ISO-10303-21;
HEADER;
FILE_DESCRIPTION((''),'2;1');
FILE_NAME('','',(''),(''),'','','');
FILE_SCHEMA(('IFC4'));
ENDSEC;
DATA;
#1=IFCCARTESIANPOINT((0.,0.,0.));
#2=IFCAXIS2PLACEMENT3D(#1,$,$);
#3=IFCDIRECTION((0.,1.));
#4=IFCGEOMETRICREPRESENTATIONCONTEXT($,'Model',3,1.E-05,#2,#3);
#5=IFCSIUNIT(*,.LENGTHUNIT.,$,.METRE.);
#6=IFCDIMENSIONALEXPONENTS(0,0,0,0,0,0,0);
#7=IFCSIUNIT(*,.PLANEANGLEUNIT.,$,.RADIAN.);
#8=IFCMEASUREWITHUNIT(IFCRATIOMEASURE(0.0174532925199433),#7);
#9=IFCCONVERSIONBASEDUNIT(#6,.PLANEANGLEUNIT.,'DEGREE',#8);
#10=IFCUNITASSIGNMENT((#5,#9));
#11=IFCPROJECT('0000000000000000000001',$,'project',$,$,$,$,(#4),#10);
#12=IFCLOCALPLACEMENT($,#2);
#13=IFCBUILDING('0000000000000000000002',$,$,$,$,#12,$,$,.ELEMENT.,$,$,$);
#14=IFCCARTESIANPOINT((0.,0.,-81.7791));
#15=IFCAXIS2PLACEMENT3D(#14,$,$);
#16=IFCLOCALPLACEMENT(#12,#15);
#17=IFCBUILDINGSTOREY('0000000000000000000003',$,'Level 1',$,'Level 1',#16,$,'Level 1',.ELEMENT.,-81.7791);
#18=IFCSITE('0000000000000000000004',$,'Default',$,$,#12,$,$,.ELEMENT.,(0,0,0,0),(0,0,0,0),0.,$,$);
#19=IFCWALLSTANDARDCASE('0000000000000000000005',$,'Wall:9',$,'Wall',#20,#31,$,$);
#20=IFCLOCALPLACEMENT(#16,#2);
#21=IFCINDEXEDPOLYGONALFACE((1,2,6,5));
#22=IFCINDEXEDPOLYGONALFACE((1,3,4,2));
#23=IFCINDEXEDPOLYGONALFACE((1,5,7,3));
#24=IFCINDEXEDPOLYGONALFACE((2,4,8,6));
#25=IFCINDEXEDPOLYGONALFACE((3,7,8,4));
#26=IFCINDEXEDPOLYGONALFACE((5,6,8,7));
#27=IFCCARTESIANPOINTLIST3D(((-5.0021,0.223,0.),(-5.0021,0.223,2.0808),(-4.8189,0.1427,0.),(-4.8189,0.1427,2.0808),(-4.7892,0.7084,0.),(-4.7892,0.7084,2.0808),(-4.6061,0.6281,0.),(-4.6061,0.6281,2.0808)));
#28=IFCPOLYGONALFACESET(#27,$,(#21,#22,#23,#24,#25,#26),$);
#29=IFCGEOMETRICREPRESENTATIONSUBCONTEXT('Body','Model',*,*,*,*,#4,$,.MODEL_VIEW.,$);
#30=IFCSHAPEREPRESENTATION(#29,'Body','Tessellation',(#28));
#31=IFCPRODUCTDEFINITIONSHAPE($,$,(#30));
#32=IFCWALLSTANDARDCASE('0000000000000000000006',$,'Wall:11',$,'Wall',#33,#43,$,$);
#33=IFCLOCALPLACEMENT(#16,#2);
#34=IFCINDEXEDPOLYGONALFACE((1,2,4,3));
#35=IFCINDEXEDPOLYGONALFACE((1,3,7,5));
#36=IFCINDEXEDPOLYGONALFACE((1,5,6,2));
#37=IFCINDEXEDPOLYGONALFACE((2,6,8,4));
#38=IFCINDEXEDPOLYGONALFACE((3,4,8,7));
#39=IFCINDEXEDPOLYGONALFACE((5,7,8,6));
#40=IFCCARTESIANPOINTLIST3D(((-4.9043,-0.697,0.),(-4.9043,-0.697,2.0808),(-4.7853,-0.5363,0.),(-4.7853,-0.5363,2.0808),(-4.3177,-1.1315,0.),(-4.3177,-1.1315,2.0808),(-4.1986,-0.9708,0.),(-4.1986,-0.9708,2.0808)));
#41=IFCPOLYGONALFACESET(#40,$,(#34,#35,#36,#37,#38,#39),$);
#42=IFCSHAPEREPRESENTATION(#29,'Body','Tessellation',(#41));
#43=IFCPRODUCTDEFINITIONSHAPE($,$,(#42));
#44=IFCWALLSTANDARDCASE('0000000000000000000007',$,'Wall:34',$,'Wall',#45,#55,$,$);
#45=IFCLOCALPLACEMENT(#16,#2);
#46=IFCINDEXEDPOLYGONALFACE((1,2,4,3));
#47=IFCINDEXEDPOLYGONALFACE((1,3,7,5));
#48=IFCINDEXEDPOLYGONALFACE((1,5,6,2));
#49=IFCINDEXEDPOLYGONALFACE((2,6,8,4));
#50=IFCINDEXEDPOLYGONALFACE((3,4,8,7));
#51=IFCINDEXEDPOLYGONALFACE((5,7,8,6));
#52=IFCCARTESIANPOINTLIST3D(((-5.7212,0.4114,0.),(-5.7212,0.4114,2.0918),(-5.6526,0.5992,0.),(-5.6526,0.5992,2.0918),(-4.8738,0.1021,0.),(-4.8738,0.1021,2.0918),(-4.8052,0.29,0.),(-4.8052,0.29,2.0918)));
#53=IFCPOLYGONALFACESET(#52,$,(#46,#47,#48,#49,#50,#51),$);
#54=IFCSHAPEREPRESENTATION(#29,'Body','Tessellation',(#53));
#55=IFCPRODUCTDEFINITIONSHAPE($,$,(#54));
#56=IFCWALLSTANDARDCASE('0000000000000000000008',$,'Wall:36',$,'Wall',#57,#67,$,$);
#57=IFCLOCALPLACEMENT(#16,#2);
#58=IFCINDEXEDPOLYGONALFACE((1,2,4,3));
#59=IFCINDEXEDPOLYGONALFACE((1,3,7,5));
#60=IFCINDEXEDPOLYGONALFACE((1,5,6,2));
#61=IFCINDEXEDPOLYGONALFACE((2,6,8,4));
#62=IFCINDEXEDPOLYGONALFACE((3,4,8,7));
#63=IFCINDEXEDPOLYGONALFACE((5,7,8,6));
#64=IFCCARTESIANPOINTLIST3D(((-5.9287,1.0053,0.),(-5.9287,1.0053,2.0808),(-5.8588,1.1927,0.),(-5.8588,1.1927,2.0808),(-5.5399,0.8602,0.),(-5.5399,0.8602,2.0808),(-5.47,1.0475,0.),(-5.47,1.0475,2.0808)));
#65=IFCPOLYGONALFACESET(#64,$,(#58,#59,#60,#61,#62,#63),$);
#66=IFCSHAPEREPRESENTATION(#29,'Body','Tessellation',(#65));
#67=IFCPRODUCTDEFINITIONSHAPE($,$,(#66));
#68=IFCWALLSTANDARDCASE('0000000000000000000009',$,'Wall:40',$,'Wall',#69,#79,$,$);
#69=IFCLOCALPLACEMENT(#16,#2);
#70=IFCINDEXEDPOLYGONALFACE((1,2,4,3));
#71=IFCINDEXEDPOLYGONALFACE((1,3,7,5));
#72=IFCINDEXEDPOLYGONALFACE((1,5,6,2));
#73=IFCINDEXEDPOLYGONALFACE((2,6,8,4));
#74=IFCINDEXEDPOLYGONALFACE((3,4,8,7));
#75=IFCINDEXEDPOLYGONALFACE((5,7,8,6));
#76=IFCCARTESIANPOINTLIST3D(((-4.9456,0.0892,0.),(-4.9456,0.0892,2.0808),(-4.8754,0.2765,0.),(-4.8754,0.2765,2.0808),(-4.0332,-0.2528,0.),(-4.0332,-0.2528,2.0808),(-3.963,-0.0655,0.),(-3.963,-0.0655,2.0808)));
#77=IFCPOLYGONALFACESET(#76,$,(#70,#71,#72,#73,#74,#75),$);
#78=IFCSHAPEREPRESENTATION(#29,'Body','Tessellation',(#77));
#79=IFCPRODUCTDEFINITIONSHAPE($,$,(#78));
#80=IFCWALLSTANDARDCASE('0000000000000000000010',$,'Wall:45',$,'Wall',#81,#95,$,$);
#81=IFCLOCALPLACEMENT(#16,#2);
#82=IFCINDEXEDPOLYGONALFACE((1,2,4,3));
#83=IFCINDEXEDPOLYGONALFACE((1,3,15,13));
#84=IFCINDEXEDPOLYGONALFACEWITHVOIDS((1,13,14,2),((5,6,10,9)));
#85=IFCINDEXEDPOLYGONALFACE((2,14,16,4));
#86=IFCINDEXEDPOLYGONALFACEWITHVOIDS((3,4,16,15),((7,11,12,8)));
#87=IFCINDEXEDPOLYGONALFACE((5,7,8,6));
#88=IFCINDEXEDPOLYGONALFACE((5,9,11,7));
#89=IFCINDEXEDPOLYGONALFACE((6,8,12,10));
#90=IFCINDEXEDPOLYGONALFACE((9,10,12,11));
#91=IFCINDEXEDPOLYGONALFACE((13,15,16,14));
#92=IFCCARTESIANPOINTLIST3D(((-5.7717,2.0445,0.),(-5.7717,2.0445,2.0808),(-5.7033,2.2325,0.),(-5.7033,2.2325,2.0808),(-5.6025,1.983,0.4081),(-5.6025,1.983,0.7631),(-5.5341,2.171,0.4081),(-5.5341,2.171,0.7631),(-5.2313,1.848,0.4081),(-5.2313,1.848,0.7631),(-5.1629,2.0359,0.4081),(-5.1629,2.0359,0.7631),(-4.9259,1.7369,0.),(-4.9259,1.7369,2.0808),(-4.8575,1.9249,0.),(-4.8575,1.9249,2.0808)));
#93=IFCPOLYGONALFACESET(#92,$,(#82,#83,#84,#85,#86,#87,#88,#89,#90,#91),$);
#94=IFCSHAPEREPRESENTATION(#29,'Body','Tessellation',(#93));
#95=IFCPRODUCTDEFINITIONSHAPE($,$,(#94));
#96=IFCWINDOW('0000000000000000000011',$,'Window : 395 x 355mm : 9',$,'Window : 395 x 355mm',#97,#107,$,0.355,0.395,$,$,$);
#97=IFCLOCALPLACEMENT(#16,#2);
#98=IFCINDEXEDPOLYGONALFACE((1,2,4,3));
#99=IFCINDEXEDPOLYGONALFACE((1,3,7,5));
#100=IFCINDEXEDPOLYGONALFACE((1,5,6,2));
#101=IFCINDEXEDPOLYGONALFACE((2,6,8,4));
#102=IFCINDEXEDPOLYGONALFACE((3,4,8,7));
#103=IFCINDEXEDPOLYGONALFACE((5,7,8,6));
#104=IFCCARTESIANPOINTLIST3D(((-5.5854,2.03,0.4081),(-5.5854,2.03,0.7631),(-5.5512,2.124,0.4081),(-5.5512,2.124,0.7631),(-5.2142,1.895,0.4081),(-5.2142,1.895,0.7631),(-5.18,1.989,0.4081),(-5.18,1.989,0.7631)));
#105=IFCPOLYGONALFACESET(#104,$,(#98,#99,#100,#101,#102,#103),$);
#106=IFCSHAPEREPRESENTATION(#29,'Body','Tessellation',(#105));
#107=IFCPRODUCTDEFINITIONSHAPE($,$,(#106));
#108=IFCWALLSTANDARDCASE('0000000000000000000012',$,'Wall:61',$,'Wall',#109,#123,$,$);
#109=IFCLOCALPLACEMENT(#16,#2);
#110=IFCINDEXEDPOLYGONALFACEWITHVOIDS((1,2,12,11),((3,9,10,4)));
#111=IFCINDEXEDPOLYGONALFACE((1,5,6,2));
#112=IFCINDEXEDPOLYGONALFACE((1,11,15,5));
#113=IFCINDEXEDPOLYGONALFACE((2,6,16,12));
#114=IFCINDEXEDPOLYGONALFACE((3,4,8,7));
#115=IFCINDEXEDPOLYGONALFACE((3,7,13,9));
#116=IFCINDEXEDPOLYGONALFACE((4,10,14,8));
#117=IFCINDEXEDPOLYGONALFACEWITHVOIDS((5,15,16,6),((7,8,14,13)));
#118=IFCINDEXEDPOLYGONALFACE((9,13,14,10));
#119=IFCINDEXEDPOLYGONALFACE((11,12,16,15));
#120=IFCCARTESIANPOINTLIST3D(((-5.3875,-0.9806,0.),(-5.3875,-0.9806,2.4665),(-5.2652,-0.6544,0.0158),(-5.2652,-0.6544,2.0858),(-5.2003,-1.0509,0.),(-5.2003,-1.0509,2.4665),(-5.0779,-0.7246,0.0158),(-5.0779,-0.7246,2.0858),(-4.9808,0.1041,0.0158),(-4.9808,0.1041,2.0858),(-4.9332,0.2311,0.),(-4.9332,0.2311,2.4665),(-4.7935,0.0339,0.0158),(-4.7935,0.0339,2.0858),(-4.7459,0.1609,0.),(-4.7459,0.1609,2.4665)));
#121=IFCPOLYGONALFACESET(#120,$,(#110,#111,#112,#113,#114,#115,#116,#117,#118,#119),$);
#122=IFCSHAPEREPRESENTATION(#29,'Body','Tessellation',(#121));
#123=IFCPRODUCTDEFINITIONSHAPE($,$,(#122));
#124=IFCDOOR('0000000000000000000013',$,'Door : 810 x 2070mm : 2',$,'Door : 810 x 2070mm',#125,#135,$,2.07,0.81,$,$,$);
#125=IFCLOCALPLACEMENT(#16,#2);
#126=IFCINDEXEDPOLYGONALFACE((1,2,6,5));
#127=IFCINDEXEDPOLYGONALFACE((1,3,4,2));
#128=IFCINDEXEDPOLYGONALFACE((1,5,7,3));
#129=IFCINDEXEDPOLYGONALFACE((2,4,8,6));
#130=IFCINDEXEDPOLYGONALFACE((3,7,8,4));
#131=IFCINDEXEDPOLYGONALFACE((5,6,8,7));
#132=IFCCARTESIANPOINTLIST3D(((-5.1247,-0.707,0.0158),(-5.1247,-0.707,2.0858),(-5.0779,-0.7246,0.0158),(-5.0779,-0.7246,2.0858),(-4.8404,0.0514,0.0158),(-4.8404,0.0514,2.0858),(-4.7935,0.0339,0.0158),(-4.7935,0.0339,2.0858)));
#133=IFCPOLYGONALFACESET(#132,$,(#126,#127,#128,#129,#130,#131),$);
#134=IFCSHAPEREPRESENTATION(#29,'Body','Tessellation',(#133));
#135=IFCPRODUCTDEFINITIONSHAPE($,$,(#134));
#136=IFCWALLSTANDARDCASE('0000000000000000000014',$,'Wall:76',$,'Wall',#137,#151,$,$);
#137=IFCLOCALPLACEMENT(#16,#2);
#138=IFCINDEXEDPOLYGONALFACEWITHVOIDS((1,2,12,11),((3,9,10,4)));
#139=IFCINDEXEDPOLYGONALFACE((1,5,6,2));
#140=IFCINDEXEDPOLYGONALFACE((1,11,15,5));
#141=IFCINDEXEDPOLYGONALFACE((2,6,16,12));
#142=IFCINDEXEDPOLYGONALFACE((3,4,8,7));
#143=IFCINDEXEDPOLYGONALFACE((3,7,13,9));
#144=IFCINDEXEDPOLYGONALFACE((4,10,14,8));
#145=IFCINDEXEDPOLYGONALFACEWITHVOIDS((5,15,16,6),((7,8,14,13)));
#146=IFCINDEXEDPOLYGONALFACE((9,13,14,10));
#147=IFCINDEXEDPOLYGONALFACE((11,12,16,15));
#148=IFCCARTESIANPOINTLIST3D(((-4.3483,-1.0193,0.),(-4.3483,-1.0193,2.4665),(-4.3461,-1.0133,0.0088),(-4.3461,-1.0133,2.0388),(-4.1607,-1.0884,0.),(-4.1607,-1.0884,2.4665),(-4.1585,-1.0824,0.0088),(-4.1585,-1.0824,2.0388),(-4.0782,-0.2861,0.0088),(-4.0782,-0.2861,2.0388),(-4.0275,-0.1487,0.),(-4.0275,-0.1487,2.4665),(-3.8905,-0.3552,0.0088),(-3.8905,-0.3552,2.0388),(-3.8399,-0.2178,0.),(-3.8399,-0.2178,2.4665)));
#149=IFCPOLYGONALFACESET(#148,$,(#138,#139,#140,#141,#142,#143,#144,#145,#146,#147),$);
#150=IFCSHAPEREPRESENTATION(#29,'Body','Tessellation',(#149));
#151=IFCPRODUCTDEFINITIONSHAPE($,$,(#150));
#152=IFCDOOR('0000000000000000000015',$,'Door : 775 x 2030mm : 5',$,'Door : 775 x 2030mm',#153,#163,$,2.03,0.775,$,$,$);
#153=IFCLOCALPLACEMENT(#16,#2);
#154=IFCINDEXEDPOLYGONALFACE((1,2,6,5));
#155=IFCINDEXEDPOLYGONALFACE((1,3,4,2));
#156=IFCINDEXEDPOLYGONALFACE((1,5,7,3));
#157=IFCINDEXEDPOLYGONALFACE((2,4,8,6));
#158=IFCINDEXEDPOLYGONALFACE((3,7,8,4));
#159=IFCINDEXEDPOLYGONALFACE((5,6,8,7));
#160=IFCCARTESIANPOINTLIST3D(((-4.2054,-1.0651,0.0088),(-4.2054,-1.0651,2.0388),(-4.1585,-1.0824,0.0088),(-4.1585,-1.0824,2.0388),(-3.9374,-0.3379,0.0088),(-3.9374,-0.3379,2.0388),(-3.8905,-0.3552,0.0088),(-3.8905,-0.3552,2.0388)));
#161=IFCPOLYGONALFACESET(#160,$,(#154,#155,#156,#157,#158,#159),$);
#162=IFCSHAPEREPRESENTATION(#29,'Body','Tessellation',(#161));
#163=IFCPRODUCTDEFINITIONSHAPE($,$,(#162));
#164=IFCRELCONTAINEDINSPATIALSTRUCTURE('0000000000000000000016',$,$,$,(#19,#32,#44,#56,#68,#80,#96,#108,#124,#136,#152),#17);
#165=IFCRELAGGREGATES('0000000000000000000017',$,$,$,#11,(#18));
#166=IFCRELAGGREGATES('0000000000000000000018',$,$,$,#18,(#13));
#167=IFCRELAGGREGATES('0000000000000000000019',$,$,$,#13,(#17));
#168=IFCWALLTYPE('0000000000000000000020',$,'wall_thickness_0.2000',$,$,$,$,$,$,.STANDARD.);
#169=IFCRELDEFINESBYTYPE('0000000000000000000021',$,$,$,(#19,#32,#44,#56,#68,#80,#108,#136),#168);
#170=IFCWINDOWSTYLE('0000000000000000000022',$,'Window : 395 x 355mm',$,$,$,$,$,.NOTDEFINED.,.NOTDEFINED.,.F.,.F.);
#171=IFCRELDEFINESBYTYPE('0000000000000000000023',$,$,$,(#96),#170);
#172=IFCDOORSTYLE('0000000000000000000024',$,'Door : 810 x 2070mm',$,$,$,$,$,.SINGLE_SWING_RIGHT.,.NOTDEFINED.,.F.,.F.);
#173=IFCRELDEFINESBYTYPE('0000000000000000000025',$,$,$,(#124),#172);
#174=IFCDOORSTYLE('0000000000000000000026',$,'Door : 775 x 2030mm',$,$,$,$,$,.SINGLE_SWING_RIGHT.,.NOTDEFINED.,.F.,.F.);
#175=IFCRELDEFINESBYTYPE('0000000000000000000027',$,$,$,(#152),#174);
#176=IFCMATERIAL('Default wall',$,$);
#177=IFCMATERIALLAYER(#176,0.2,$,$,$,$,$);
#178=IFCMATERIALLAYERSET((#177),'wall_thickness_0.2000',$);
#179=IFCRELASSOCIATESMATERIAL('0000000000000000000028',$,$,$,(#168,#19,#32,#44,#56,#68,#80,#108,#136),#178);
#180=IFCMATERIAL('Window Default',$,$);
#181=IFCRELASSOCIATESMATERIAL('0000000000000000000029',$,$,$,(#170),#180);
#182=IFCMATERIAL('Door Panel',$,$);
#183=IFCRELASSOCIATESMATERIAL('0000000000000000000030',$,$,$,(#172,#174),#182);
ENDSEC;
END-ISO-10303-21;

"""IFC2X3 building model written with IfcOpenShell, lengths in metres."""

from ifc_helpers import new_model, entity, si_unit, converted_unit, direction, frame, frame_2d, origin, origin_2d_with_axis, place, context, subcontext, project, spatial, polyline, rectangle, outline, extrude, source, transform, mapped, material, layer, layer_set, layer_usage, type_object, type_shapes, element, fill, save


model = new_model("IFC2X3")

# Units and contexts
model_context = context("Model", 3, precision=1e-05, world=origin(), true_north=direction((0.0, 1.0)))
body_context = subcontext(model_context, "Body", "Model", "MODEL_VIEW")
ifc_project = project(units=[si_unit("LENGTHUNIT", "METRE"), converted_unit("PLANEANGLEUNIT", "DEGREE", entity("IfcRatioMeasure", 0.0174532925199433), si_unit("PLANEANGLEUNIT", "RADIAN"), dimensions=[0, 0, 0, 0, 0, 0, 0])], contexts=[model_context])

# Site, building, storey
placement_1 = place(None, origin())
site = spatial("IfcSite", under=ifc_project, at=placement_1, Name="Default", CompositionType="ELEMENT", RefLatitude=(0, 0, 0, 0), RefLongitude=(0, 0, 0, 0), RefElevation=0.0)
building = spatial("IfcBuilding", under=site, at=placement_1, CompositionType="ELEMENT")
storey_placement = place(placement_1, frame((0.0, 0.0, -81.7791)))
storey = spatial("IfcBuildingStorey", under=building, at=storey_placement, Name="Level 1", ObjectType="Level 1", LongName="Level 1", CompositionType="ELEMENT", Elevation=-81.7791)

# Walls
ifc_material_1 = material(Name="Default wall")
ifc_layer_1 = layer(ifc_material_1, 0.2)
ifc_layer_set_1 = layer_set([ifc_layer_1], Name="wall_thickness_0.2000")
ifc_layer_usage_1 = layer_usage(ifc_layer_set_1, "AXIS2", "POSITIVE", -0.1)
wall_type_1 = type_object("IfcWallType", Name="wall_thickness_0.2000", PredefinedType="STANDARD", material=ifc_layer_set_1)
wall_1_placement = place(storey_placement, frame((-4.6976, 0.6683, 0.0), z_axis=(0.0, 0.0, 1.0), x_axis=(-0.401525, -0.915848, 0.0)))
element("IfcWallStandardCase", 1, at=wall_1_placement, inside=storey, type_object=wall_type_1, material=ifc_layer_usage_1, Name="Wall:9", ObjectType="Wall", context=body_context, shape_type="SweptSolid", body=[
    extrude(outline(polyline([(0.5301, -0.1), (0.5301, 0.1), (0.0, 0.1), (0.0, -0.1), (0.5301, -0.1)])), origin(), (0.0, 0.0, 1.0), 2.0808),
])
wall_2_placement = place(storey_placement, frame((-4.8448, -0.6167, 0.0), z_axis=(0.0, 0.0, 1.0), x_axis=(0.803592, -0.595181, 0.0)))
element("IfcWallStandardCase", 2, at=wall_2_placement, inside=storey, type_object=wall_type_1, material=ifc_layer_usage_1, Name="Wall:11", ObjectType="Wall", context=body_context, shape_type="SweptSolid", body=[
    extrude(outline(polyline([(0.73, -0.1), (0.73, 0.1), (0.0, 0.1), (0.0, -0.1), (0.73, -0.1)])), origin(), (0.0, 0.0, 1.0), 2.0808),
])
wall_3_placement = place(storey_placement, frame((-5.6869, 0.5053, 0.0), z_axis=(0.0, 0.0, 1.0), x_axis=(0.939382, -0.342872, 0.0)))
element("IfcWallStandardCase", 3, at=wall_3_placement, inside=storey, type_object=wall_type_1, material=ifc_layer_usage_1, Name="Wall:34", ObjectType="Wall", context=body_context, shape_type="SweptSolid", body=[
    extrude(outline(polyline([(0.902, -0.1), (0.902, 0.1), (0.0, 0.1), (0.0, -0.1), (0.902, -0.1)])), origin(), (0.0, 0.0, 1.0), 2.0918),
])
wall_4_placement = place(storey_placement, frame((-5.505, 0.9538, 0.0), z_axis=(0.0, 0.0, 1.0), x_axis=(-0.93684, 0.349758, 0.0)))
element("IfcWallStandardCase", 4, at=wall_4_placement, inside=storey, type_object=wall_type_1, material=ifc_layer_usage_1, Name="Wall:36", ObjectType="Wall", context=body_context, shape_type="SweptSolid", body=[
    extrude(outline(polyline([(0.415, -0.1), (0.415, 0.1), (0.0, 0.1), (0.0, -0.1), (0.415, -0.1)])), origin(), (0.0, 0.0, 1.0), 2.0808),
])
wall_5_placement = place(storey_placement, frame((-4.9105, 0.1828, 0.0), z_axis=(0.0, 0.0, 1.0), x_axis=(0.936404, -0.350923, 0.0)))
element("IfcWallStandardCase", 5, at=wall_5_placement, inside=storey, type_object=wall_type_1, material=ifc_layer_usage_1, Name="Wall:40", ObjectType="Wall", context=body_context, shape_type="SweptSolid", body=[
    extrude(outline(polyline([(0.9744, -0.1), (0.9744, 0.1), (0.0, 0.1), (0.0, -0.1), (0.9744, -0.1)])), origin(), (0.0, 0.0, 1.0), 2.0808),
])

# Wall, opening, window
wall_6_placement = place(storey_placement, frame((-5.7375, 2.1385, 0.0), z_axis=(0.0, 0.0, 1.0), x_axis=(0.939771, -0.341805, 0.0)))
wall_6 = element("IfcWallStandardCase", 6, at=wall_6_placement, inside=storey, type_object=wall_type_1, material=ifc_layer_usage_1, Name="Wall:45", ObjectType="Wall", context=body_context, shape_type="SweptSolid", body=[
    extrude(outline(polyline([(0.9, -0.1), (0.9, 0.1), (0.0, 0.1), (0.0, -0.1), (0.9, -0.1)])), origin(), (0.0, 0.0, 1.0), 2.0808),
])
opening_1_placement = place(wall_6_placement, frame((0.18, -0.1, 0.4081)))
opening_1 = element("IfcOpeningElement", 7, at=opening_1_placement, cuts=wall_6, ObjectType="Opening", context=body_context, shape_type="SweptSolid", body=[
    extrude(rectangle(XDim=0.395, YDim=0.355, at=frame_2d((0.1775, 0.1975), x_axis=(0.0, 1.0))), frame((0.0, 0.0, 0.0), z_axis=(0.0, 1.0, 0.0), x_axis=(0.0, 0.0, 1.0)), (0.0, 0.0, 1.0), 0.2),
])
ifc_material_2 = material(Name="Window Default")
window_style_1 = type_object("IfcWindowStyle", Name="Window : 395 x 355mm", ConstructionType="NOTDEFINED", OperationType="NOTDEFINED", ParameterTakesPrecedence=False, Sizeable=False, material=ifc_material_2)
shared_shape_1 = source(origin(), body_context, "Body", "SweptSolid", [
    extrude(rectangle(XDim=0.1, YDim=0.395, at=origin_2d_with_axis()), frame((0.1975, 0.1, 0.0), z_axis=(0.0, 0.0, 1.0), x_axis=(0.0, 1.0, 0.0)), (0.0, 0.0, 1.0), 0.355),
])
type_shapes(window_style_1, [shared_shape_1])
window_1_placement = place(opening_1_placement, origin())
window_1 = element("IfcWindow", 8, at=window_1_placement, inside=storey, type_object=window_style_1, Name="Window : 395 x 355mm : 9", ObjectType="Window : 395 x 355mm", OverallHeight=0.355, OverallWidth=0.395, context=body_context, shape_type="MappedRepresentation", body=[
    mapped(shared_shape_1, transform((0.0, 0.0, 0.0), scale=1.0)),
])
fill(opening_1, window_1)

# Walls, openings, doors
wall_7_placement = place(storey_placement, frame((-4.8395, 0.196, 0.0), z_axis=(0.0, 0.0, 1.0), x_axis=(-0.351109, -0.936334, 0.0)))
wall_7 = element("IfcWallStandardCase", 9, at=wall_7_placement, inside=storey, type_object=wall_type_1, material=ifc_layer_usage_1, Name="Wall:61", ObjectType="Wall", context=body_context, shape_type="SweptSolid", body=[
    extrude(outline(polyline([(1.2942, -0.1), (1.2942, 0.1), (0.0, 0.1), (0.0, -0.1), (1.2942, -0.1)])), origin(), (0.0, 0.0, 1.0), 2.4665),
])
opening_2_placement = place(wall_7_placement, frame((0.1357, -0.1, 0.0158)))
opening_2 = element("IfcOpeningElement", 10, at=opening_2_placement, cuts=wall_7, ObjectType="Opening", context=body_context, shape_type="SweptSolid", body=[
    extrude(rectangle(XDim=0.81, YDim=2.07, at=frame_2d((1.035, 0.405), x_axis=(0.0, 1.0))), frame((0.0, 0.0, 0.0), z_axis=(0.0, 1.0, 0.0), x_axis=(0.0, 0.0, 1.0)), (0.0, 0.0, 1.0), 0.2),
])
ifc_material_3 = material(Name="Door Panel")
door_style_1 = type_object("IfcDoorStyle", Name="Door : 810 x 2070mm", ConstructionType="NOTDEFINED", OperationType="SINGLE_SWING_RIGHT", ParameterTakesPrecedence=False, Sizeable=False, material=ifc_material_3)
shared_shape_2 = source(origin(), body_context, "Body", "SweptSolid", [
    extrude(rectangle(XDim=0.05, YDim=0.81, at=origin_2d_with_axis()), frame((0.405, 0.175, 0.0), z_axis=(0.0, 0.0, 1.0), x_axis=(0.0, 1.0, 0.0)), (0.0, 0.0, 1.0), 2.07),
])
type_shapes(door_style_1, [shared_shape_2])
door_1_placement = place(opening_2_placement, origin())
door_1 = element("IfcDoor", 11, at=door_1_placement, inside=storey, type_object=door_style_1, Name="Door : 810 x 2070mm : 2", ObjectType="Door : 810 x 2070mm", OverallHeight=2.07, OverallWidth=0.81, context=body_context, shape_type="MappedRepresentation", body=[
    mapped(shared_shape_2, transform((0.0, 0.0, 0.0), scale=1.0)),
])
fill(opening_2, door_1)
wall_8_placement = place(storey_placement, frame((-3.9337, -0.1832, 0.0), z_axis=(0.0, 0.0, 1.0), x_axis=(-0.345762, -0.938322, 0.0)))
wall_8 = element("IfcWallStandardCase", 12, at=wall_8_placement, inside=storey, type_object=wall_type_1, material=ifc_layer_usage_1, Name="Wall:76", ObjectType="Wall", context=body_context, shape_type="SweptSolid", body=[
    extrude(outline(polyline([(0.9278, -0.1), (0.9278, 0.1), (0.0, 0.1), (0.0, -0.1), (0.9278, -0.1)])), origin(), (0.0, 0.0, 1.0), 2.4665),
])
opening_3_placement = place(wall_8_placement, frame((0.1464, -0.1, 0.0088)))
opening_3 = element("IfcOpeningElement", 13, at=opening_3_placement, cuts=wall_8, ObjectType="Opening", context=body_context, shape_type="SweptSolid", body=[
    extrude(rectangle(XDim=0.775, YDim=2.03, at=frame_2d((1.015, 0.3875), x_axis=(0.0, 1.0))), frame((0.0, 0.0, 0.0), z_axis=(0.0, 1.0, 0.0), x_axis=(0.0, 0.0, 1.0)), (0.0, 0.0, 1.0), 0.2),
])
door_style_2 = type_object("IfcDoorStyle", Name="Door : 775 x 2030mm", ConstructionType="NOTDEFINED", OperationType="SINGLE_SWING_RIGHT", ParameterTakesPrecedence=False, Sizeable=False, material=ifc_material_3)
shared_shape_3 = source(origin(), body_context, "Body", "SweptSolid", [
    extrude(rectangle(XDim=0.05, YDim=0.775, at=origin_2d_with_axis()), frame((0.3875, 0.175, 0.0), z_axis=(0.0, 0.0, 1.0), x_axis=(0.0, 1.0, 0.0)), (0.0, 0.0, 1.0), 2.03),
])
type_shapes(door_style_2, [shared_shape_3])
door_2_placement = place(opening_3_placement, origin())
door_2 = element("IfcDoor", 14, at=door_2_placement, inside=storey, type_object=door_style_2, Name="Door : 775 x 2030mm : 5", ObjectType="Door : 775 x 2030mm", OverallHeight=2.03, OverallWidth=0.775, context=body_context, shape_type="MappedRepresentation", body=[
    mapped(shared_shape_3, transform((0.0, 0.0, 0.0), scale=1.0)),
])
fill(opening_3, door_2)

save(model, "model.ifc")
